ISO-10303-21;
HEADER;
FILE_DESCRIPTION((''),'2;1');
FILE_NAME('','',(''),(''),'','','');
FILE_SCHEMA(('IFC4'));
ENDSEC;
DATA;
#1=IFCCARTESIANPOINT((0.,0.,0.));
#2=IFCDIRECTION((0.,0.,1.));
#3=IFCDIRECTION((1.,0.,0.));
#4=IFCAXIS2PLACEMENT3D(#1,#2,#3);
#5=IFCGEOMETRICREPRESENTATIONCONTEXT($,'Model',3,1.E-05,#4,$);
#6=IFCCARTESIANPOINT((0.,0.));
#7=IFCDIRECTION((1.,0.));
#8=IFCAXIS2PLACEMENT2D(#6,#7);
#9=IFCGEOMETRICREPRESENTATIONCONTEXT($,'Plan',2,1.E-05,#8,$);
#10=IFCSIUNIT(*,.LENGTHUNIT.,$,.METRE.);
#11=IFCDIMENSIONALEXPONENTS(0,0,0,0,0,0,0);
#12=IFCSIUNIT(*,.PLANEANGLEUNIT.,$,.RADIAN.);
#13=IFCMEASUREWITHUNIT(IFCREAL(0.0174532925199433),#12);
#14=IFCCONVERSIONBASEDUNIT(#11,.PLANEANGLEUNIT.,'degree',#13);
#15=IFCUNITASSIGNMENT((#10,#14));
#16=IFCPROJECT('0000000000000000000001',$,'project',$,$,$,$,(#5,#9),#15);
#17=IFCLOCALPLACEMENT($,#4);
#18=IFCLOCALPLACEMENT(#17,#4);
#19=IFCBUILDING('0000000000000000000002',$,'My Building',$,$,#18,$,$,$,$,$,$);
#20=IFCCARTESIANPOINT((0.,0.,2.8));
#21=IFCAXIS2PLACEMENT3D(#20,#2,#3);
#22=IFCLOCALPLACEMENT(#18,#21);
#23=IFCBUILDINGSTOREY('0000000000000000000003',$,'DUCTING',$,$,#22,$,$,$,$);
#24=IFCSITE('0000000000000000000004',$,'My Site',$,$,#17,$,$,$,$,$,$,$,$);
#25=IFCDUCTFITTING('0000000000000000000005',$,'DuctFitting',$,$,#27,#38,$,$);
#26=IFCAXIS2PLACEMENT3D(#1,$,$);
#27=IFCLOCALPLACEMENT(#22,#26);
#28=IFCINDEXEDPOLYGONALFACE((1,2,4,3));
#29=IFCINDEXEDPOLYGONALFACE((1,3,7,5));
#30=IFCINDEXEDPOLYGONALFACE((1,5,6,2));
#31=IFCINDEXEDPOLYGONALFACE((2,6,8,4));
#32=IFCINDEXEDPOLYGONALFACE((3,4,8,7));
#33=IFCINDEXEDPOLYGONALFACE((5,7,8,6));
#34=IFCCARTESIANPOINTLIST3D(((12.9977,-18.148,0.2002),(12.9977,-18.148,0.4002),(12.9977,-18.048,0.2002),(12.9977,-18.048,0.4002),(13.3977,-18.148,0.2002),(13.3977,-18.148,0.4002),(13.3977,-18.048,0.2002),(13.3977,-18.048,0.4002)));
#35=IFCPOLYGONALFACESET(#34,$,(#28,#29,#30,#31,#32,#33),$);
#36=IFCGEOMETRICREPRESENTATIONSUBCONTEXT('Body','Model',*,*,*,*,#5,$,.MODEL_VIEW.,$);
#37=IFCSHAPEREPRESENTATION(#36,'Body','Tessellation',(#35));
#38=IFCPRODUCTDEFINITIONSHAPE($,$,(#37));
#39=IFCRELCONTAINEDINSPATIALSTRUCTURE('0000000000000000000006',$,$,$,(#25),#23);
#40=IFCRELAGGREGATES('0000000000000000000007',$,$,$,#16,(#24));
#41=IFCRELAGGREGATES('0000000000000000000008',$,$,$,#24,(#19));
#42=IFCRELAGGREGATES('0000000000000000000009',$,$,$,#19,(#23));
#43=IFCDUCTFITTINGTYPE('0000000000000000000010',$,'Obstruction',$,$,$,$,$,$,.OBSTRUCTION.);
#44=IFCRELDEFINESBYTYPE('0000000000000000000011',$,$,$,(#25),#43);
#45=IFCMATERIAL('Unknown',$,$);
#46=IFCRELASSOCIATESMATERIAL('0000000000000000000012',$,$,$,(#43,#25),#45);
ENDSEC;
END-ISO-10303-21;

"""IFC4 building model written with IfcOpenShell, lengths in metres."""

from ifc_helpers import new_model, entity, si_unit, converted_unit, frame, origin_with_axes, origin_2d_with_axis, place, context, subcontext, project, spatial, rectangle, extrude, material, material_profile, profile_set, profile_usage, type_object, element, save


model = new_model("IFC4")

# Units and contexts
model_context = context("Model", 3, precision=1e-05, world=origin_with_axes())
plan_context = context("Plan", 2, precision=1e-05, world=origin_2d_with_axis())
body_context = subcontext(model_context, "Body", "Model", "MODEL_VIEW")
ifc_project = project(units=[si_unit("LENGTHUNIT", "METRE"), converted_unit("PLANEANGLEUNIT", "degree", entity("IfcReal", 0.0174532925199433), si_unit("PLANEANGLEUNIT", "RADIAN"), dimensions=[0, 0, 0, 0, 0, 0, 0])], contexts=[model_context, plan_context])

# Site, building, storey
site_placement = place(None, origin_with_axes())
site = spatial("IfcSite", under=ifc_project, at=site_placement, Name="My Site")
building_placement = place(site_placement, origin_with_axes())
building = spatial("IfcBuilding", under=site, at=building_placement, Name="My Building")
storey_placement = place(building_placement, frame((0.0, 0.0, 2.8), z_axis=(0.0, 0.0, 1.0), x_axis=(1.0, 0.0, 0.0)))
storey = spatial("IfcBuildingStorey", under=building, at=storey_placement, Name="DUCTING")

# Shared definitions
ifc_material = material(Name="Unknown")

# Duct fitting
ifc_material_profile_1 = material_profile(ifc_material, rectangle(XDim=0.4, YDim=0.2))
ifc_profile_set_1 = profile_set([ifc_material_profile_1])
duct_fitting_type_1 = type_object("IfcDuctFittingType", Name="Obstruction", PredefinedType="OBSTRUCTION", material=ifc_profile_set_1)
ifc_profile_usage_1 = profile_usage(ifc_profile_set_1, cardinal=5)
duct_fitting_1_placement = place(storey_placement, frame((13.1977, -18.048, 0.3002), z_axis=(0.0, -1.0, 0.0), x_axis=(1.0, 0.0, 0.0)))
element("IfcDuctFitting", 1, at=duct_fitting_1_placement, inside=storey, type_object=duct_fitting_type_1, material=ifc_profile_usage_1, Name="DuctFitting", context=body_context, shape_type="SweptSolid", body=[
    extrude(rectangle(XDim=0.4, YDim=0.2), origin_with_axes(), (0.0, 0.0, 1.0), 0.1),
])

save(model, "model.ifc")
